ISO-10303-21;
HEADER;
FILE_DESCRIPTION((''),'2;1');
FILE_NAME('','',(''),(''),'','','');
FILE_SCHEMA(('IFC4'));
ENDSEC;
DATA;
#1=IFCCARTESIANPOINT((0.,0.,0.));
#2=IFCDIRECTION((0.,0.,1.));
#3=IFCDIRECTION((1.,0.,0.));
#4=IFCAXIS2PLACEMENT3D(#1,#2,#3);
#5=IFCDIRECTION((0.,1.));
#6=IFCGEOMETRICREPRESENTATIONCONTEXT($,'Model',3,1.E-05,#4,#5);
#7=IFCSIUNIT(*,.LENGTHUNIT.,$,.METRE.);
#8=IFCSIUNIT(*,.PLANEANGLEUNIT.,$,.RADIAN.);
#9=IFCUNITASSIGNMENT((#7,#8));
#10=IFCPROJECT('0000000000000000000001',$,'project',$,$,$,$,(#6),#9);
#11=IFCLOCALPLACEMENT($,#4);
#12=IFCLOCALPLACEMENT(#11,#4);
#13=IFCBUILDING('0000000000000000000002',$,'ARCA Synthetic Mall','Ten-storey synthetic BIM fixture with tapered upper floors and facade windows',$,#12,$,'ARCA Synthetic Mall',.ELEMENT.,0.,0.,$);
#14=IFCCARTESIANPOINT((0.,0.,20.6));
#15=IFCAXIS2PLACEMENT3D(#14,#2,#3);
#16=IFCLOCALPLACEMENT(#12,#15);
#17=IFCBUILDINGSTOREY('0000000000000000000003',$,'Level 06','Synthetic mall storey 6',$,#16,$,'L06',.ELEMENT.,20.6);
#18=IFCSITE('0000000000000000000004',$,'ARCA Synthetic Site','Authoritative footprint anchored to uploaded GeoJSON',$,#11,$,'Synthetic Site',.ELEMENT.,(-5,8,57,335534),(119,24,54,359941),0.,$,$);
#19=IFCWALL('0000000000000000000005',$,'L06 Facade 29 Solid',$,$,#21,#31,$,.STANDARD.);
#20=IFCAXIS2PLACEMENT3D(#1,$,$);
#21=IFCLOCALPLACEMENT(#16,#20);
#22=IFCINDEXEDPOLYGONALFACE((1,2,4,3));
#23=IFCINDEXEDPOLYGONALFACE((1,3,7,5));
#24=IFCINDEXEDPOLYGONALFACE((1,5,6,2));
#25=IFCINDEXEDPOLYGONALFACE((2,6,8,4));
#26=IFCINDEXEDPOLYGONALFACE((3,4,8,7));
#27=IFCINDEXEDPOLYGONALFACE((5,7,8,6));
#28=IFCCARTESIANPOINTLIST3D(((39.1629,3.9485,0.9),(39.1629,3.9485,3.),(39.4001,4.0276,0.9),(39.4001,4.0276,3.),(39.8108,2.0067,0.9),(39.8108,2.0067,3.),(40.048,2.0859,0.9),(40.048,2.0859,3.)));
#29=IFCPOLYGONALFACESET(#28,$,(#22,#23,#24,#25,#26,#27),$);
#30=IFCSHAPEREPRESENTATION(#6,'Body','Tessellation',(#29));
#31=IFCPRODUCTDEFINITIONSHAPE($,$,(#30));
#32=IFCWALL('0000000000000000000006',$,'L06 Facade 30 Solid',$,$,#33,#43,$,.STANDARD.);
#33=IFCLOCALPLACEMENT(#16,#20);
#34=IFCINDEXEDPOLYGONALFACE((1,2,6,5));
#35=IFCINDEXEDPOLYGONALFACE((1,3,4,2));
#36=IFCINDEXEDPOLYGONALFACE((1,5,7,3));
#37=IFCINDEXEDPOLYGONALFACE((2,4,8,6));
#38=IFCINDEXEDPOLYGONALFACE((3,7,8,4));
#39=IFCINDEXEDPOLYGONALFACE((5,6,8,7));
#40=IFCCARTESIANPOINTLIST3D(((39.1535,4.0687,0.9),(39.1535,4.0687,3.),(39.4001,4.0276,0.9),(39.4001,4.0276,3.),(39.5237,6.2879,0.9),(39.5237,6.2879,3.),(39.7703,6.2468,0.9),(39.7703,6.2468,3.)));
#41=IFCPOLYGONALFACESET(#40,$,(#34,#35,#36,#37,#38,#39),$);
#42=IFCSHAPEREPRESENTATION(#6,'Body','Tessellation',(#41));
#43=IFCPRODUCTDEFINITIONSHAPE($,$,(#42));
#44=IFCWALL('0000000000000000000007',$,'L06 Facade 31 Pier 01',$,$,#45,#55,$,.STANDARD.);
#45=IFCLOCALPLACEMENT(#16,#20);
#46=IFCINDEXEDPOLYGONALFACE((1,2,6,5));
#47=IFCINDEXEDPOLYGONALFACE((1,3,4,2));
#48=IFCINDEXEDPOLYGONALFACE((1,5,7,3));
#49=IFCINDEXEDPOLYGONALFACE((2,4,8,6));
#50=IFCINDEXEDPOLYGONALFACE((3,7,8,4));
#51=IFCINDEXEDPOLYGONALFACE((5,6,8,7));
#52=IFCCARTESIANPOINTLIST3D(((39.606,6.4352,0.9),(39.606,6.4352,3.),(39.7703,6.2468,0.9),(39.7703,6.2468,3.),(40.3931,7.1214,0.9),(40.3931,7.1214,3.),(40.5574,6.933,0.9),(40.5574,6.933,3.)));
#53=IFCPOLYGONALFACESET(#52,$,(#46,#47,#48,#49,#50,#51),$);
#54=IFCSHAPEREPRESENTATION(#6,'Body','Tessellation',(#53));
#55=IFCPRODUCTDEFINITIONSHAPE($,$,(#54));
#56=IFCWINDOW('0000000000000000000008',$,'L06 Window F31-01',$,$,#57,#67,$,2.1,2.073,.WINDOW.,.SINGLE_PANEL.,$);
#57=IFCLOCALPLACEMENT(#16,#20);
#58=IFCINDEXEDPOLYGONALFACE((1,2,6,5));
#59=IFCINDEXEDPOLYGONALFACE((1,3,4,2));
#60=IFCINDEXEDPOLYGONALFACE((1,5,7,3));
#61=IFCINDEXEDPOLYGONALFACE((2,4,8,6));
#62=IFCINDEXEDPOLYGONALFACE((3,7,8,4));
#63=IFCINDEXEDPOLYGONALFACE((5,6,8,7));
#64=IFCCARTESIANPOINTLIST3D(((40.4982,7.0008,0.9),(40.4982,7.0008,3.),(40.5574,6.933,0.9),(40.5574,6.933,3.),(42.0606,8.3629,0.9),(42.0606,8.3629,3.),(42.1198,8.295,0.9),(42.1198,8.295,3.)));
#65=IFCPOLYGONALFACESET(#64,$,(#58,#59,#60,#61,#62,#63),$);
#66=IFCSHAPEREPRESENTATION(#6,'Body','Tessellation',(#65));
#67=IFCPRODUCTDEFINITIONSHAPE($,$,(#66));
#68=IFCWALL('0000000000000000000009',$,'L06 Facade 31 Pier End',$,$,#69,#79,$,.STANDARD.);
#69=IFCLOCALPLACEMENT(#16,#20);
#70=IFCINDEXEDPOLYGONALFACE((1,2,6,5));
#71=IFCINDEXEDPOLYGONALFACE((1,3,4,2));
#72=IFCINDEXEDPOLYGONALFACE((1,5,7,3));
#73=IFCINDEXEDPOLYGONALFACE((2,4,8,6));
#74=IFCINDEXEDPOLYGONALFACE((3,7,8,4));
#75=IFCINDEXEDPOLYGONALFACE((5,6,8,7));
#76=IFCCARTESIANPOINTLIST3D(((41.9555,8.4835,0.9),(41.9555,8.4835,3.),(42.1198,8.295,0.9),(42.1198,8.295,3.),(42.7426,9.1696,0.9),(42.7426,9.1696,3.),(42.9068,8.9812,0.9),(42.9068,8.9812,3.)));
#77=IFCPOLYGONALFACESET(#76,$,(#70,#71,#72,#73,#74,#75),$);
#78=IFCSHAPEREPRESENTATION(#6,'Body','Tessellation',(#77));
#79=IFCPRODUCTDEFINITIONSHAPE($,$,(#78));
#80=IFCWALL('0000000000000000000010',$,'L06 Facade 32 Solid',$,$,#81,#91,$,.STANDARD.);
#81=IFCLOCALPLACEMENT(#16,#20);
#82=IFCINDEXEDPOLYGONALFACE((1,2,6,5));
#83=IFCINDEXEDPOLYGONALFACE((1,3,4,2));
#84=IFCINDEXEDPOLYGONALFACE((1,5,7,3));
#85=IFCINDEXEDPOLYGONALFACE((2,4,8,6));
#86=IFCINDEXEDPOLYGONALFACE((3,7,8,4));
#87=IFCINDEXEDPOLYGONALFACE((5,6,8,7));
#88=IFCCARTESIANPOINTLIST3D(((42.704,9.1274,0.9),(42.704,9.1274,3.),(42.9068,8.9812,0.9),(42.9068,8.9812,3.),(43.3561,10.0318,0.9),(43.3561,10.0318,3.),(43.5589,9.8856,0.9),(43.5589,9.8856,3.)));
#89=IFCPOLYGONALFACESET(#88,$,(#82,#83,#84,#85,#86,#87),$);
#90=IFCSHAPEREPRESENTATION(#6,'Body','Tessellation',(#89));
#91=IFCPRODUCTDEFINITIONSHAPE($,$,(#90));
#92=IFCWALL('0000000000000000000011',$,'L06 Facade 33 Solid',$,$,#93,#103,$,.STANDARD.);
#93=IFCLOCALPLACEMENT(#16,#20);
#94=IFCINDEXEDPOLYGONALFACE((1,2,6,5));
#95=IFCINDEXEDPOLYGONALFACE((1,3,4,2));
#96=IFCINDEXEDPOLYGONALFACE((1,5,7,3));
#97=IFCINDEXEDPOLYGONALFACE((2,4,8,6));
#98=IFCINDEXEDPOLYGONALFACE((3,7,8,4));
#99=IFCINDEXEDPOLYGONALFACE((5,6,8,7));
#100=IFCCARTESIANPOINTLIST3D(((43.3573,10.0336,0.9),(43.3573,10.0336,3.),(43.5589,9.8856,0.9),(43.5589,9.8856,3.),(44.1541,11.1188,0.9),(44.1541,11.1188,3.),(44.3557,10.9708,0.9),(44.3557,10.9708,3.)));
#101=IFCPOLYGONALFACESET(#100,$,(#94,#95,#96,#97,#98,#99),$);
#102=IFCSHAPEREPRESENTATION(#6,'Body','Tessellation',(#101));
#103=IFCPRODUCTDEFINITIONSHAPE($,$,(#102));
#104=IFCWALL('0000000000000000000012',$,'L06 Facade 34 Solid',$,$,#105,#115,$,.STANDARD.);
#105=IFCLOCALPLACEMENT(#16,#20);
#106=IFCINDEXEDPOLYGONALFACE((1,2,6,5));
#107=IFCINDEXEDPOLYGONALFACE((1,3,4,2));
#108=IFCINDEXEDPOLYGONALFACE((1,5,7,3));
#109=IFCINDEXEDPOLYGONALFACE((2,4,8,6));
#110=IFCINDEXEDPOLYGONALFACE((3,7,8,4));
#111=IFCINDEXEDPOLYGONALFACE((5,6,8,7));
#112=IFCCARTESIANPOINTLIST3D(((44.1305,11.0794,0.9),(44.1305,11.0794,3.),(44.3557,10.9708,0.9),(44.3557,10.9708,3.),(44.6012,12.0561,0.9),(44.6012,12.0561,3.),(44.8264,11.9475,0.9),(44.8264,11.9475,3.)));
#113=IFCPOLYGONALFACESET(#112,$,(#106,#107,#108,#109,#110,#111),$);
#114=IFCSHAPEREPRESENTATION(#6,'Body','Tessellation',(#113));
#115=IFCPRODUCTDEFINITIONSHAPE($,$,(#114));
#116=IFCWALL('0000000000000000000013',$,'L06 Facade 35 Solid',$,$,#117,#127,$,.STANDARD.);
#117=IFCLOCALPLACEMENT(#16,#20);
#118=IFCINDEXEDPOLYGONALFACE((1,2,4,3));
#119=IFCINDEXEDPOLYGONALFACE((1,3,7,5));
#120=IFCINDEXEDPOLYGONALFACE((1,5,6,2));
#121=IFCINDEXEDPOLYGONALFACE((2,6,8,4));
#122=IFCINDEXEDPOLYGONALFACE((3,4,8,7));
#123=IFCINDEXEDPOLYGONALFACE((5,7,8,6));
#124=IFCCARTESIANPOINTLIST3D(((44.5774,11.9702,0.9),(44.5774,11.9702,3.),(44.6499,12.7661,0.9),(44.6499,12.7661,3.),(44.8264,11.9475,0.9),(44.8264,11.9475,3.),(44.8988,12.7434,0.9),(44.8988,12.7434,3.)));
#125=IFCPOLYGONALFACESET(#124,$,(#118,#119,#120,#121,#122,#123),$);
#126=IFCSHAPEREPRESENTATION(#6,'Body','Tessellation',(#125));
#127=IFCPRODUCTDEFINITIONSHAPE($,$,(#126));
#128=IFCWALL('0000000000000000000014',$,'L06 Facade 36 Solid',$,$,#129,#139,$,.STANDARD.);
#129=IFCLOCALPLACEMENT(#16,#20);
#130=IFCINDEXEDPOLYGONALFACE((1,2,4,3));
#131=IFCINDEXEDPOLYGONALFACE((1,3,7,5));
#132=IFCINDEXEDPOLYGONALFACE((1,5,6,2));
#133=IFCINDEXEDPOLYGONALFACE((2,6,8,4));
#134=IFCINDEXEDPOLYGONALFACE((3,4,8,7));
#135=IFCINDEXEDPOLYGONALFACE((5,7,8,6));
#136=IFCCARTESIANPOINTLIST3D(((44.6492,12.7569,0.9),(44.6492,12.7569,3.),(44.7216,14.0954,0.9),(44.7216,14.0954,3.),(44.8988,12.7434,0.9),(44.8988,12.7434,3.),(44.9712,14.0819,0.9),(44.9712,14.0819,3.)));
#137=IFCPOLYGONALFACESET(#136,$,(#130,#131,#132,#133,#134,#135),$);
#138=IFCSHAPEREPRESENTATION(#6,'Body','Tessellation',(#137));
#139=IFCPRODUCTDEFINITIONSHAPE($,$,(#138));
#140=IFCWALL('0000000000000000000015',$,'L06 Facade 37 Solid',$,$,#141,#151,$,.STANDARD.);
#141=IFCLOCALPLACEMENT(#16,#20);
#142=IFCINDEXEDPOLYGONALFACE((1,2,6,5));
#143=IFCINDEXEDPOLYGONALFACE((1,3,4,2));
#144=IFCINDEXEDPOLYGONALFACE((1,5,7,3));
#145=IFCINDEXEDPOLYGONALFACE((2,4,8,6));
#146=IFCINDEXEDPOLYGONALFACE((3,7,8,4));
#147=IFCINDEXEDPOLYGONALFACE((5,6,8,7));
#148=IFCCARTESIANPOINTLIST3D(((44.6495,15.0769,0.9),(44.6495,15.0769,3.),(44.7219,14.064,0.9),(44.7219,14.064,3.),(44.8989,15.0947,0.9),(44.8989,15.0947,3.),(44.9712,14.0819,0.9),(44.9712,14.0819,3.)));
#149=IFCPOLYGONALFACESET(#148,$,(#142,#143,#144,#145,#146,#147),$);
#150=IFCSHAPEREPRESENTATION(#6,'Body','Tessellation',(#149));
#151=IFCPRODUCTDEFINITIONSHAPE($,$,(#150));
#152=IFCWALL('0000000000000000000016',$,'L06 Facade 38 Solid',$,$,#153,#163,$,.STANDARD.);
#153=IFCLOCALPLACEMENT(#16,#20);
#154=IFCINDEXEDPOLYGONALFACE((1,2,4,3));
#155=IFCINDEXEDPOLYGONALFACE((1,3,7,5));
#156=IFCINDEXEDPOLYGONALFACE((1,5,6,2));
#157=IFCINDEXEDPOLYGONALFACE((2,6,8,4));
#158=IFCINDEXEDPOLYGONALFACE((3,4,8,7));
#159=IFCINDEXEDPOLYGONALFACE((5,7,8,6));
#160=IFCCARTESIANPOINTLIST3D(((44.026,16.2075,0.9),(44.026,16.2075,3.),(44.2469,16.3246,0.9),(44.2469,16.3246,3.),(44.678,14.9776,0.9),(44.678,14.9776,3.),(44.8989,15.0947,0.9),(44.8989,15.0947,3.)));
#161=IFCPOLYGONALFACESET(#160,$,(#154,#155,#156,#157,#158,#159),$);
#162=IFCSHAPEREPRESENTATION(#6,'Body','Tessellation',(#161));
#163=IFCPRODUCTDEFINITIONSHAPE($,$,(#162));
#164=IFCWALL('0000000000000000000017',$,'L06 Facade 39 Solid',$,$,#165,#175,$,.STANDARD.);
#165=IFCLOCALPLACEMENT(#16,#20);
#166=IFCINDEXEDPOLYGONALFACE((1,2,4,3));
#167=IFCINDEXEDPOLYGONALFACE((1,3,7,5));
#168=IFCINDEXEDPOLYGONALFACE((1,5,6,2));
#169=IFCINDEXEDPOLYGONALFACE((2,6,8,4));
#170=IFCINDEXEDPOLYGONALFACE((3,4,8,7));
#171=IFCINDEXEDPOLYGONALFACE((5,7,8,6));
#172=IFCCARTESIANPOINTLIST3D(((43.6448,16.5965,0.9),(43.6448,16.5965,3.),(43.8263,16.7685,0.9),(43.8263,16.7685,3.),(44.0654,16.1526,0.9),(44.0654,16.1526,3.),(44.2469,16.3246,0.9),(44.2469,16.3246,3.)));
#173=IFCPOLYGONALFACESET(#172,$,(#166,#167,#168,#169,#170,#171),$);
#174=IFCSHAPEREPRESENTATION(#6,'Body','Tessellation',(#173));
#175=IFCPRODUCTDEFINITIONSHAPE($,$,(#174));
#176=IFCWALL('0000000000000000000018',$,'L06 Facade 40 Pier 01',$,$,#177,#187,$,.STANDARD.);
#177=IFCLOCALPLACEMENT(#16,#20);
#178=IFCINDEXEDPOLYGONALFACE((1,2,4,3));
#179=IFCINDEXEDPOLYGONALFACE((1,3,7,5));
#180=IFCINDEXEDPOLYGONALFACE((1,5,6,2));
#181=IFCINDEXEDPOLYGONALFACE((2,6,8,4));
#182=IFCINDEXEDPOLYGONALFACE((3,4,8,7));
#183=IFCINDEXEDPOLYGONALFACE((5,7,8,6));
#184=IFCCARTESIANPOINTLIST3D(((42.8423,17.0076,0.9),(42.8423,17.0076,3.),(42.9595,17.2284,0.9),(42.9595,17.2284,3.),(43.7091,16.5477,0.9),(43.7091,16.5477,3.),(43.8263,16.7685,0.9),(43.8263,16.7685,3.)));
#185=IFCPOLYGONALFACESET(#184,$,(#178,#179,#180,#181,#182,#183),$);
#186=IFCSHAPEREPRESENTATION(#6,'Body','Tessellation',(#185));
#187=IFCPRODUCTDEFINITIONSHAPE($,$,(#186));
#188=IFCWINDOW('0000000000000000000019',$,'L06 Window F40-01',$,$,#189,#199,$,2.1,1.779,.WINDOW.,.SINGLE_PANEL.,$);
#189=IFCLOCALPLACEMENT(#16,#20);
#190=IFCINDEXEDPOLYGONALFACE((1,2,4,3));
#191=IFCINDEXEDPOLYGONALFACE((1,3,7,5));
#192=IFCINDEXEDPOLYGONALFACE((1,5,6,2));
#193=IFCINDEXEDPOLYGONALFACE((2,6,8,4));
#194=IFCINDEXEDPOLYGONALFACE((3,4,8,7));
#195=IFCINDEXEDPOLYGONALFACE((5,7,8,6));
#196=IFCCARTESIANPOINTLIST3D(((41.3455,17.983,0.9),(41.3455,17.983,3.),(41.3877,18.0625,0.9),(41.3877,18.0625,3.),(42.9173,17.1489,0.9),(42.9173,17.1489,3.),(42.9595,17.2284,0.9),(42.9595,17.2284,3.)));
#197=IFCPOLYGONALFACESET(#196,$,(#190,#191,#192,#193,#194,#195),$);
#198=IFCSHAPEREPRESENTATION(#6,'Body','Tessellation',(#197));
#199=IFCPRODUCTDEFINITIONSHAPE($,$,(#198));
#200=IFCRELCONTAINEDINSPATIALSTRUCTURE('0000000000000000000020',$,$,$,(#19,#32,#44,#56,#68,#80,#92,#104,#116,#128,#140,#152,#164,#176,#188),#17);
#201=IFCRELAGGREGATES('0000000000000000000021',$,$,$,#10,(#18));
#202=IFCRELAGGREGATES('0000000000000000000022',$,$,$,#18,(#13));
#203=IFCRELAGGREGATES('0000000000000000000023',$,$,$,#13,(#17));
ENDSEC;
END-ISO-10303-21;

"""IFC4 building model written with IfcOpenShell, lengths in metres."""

from ifc_helpers import new_model, si_unit, direction, frame, origin_with_axes, place, context, project, spatial, polyline, outline, extrude, element, save


model = new_model("IFC4")

# Units and contexts
model_context = context("Model", 3, precision=1e-05, world=origin_with_axes(), true_north=direction((0.0, 1.0)))
ifc_project = project(units=[si_unit("LENGTHUNIT", "METRE"), si_unit("PLANEANGLEUNIT", "RADIAN")], contexts=[model_context])

# Site, building, storey
site_placement = place(None, origin_with_axes())
site = spatial("IfcSite", under=ifc_project, at=site_placement, Name="ARCA Synthetic Site", Description="Authoritative footprint anchored to uploaded GeoJSON", LongName="Synthetic Site", CompositionType="ELEMENT", RefLatitude=(-5, 8, 57, 335534), RefLongitude=(119, 24, 54, 359941), RefElevation=0.0)
building_placement = place(site_placement, origin_with_axes())
building = spatial("IfcBuilding", under=site, at=building_placement, Name="ARCA Synthetic Mall", Description="Ten-storey synthetic BIM fixture with tapered upper floors and facade windows", LongName="ARCA Synthetic Mall", CompositionType="ELEMENT", ElevationOfRefHeight=0.0, ElevationOfTerrain=0.0)
storey_placement = place(building_placement, frame((0.0, 0.0, 20.6), z_axis=(0.0, 0.0, 1.0), x_axis=(1.0, 0.0, 0.0)))
storey = spatial("IfcBuildingStorey", under=building, at=storey_placement, Name="Level 06", Description="Synthetic mall storey 6", LongName="L06", CompositionType="ELEMENT", Elevation=20.6)

# Walls
wall_1_placement = place(storey_placement, frame((0.0, 0.0, 0.9), z_axis=(0.0, 0.0, 1.0), x_axis=(1.0, 0.0, 0.0)))
element("IfcWall", 1, at=wall_1_placement, inside=storey, Name="L06 Facade 29 Solid", PredefinedType="STANDARD", context=model_context, shape_type="SweptSolid", body=[
    extrude(outline(polyline([(40.048, 2.0859), (39.4001, 4.0276), (39.1629, 3.9485), (39.8108, 2.0067), (40.048, 2.0859)])), origin_with_axes(), (0.0, 0.0, 1.0), 2.1),
])
wall_2_placement = place(storey_placement, frame((0.0, 0.0, 0.9), z_axis=(0.0, 0.0, 1.0), x_axis=(1.0, 0.0, 0.0)))
element("IfcWall", 2, at=wall_2_placement, inside=storey, Name="L06 Facade 30 Solid", PredefinedType="STANDARD", context=model_context, shape_type="SweptSolid", body=[
    extrude(outline(polyline([(39.4001, 4.0276), (39.7703, 6.2468), (39.5237, 6.2879), (39.1535, 4.0687), (39.4001, 4.0276)])), origin_with_axes(), (0.0, 0.0, 1.0), 2.1),
])
wall_3_placement = place(storey_placement, frame((0.0, 0.0, 0.9), z_axis=(0.0, 0.0, 1.0), x_axis=(1.0, 0.0, 0.0)))
element("IfcWall", 3, at=wall_3_placement, inside=storey, Name="L06 Facade 31 Pier 01", PredefinedType="STANDARD", context=model_context, shape_type="SweptSolid", body=[
    extrude(outline(polyline([(39.7703, 6.2468), (40.5574, 6.933), (40.3931, 7.1214), (39.606, 6.4352), (39.7703, 6.2468)])), origin_with_axes(), (0.0, 0.0, 1.0), 2.1),
])

# Window
window_1_placement = place(storey_placement, frame((0.0, 0.0, 0.9), z_axis=(0.0, 0.0, 1.0), x_axis=(1.0, 0.0, 0.0)))
element("IfcWindow", 4, at=window_1_placement, inside=storey, Name="L06 Window F31-01", OverallHeight=2.1, OverallWidth=2.073, PartitioningType="SINGLE_PANEL", PredefinedType="WINDOW", context=model_context, shape_type="SweptSolid", body=[
    extrude(outline(polyline([(40.5574, 6.933), (42.1198, 8.295), (42.0606, 8.3629), (40.4982, 7.0008), (40.5574, 6.933)])), origin_with_axes(), (0.0, 0.0, 1.0), 2.1),
])

# Walls
wall_4_placement = place(storey_placement, frame((0.0, 0.0, 0.9), z_axis=(0.0, 0.0, 1.0), x_axis=(1.0, 0.0, 0.0)))
element("IfcWall", 5, at=wall_4_placement, inside=storey, Name="L06 Facade 31 Pier End", PredefinedType="STANDARD", context=model_context, shape_type="SweptSolid", body=[
    extrude(outline(polyline([(42.1198, 8.295), (42.9068, 8.9812), (42.7426, 9.1696), (41.9555, 8.4835), (42.1198, 8.295)])), origin_with_axes(), (0.0, 0.0, 1.0), 2.1),
])
wall_5_placement = place(storey_placement, frame((0.0, 0.0, 0.9), z_axis=(0.0, 0.0, 1.0), x_axis=(1.0, 0.0, 0.0)))
element("IfcWall", 6, at=wall_5_placement, inside=storey, Name="L06 Facade 32 Solid", PredefinedType="STANDARD", context=model_context, shape_type="SweptSolid", body=[
    extrude(outline(polyline([(42.9068, 8.9812), (43.5589, 9.8856), (43.3561, 10.0318), (42.704, 9.1274), (42.9068, 8.9812)])), origin_with_axes(), (0.0, 0.0, 1.0), 2.1),
])
wall_6_placement = place(storey_placement, frame((0.0, 0.0, 0.9), z_axis=(0.0, 0.0, 1.0), x_axis=(1.0, 0.0, 0.0)))
element("IfcWall", 7, at=wall_6_placement, inside=storey, Name="L06 Facade 33 Solid", PredefinedType="STANDARD", context=model_context, shape_type="SweptSolid", body=[
    extrude(outline(polyline([(43.5589, 9.8856), (44.3557, 10.9708), (44.1541, 11.1188), (43.3573, 10.0336), (43.5589, 9.8856)])), origin_with_axes(), (0.0, 0.0, 1.0), 2.1),
])
wall_7_placement = place(storey_placement, frame((0.0, 0.0, 0.9), z_axis=(0.0, 0.0, 1.0), x_axis=(1.0, 0.0, 0.0)))
element("IfcWall", 8, at=wall_7_placement, inside=storey, Name="L06 Facade 34 Solid", PredefinedType="STANDARD", context=model_context, shape_type="SweptSolid", body=[
    extrude(outline(polyline([(44.3557, 10.9708), (44.8264, 11.9475), (44.6012, 12.0561), (44.1305, 11.0794), (44.3557, 10.9708)])), origin_with_axes(), (0.0, 0.0, 1.0), 2.1),
])
wall_8_placement = place(storey_placement, frame((0.0, 0.0, 0.9), z_axis=(0.0, 0.0, 1.0), x_axis=(1.0, 0.0, 0.0)))
element("IfcWall", 9, at=wall_8_placement, inside=storey, Name="L06 Facade 35 Solid", PredefinedType="STANDARD", context=model_context, shape_type="SweptSolid", body=[
    extrude(outline(polyline([(44.8264, 11.9475), (44.8988, 12.7434), (44.6499, 12.7661), (44.5774, 11.9702), (44.8264, 11.9475)])), origin_with_axes(), (0.0, 0.0, 1.0), 2.1),
])
wall_9_placement = place(storey_placement, frame((0.0, 0.0, 0.9), z_axis=(0.0, 0.0, 1.0), x_axis=(1.0, 0.0, 0.0)))
element("IfcWall", 10, at=wall_9_placement, inside=storey, Name="L06 Facade 36 Solid", PredefinedType="STANDARD", context=model_context, shape_type="SweptSolid", body=[
    extrude(outline(polyline([(44.8988, 12.7434), (44.9712, 14.0819), (44.7216, 14.0954), (44.6492, 12.7569), (44.8988, 12.7434)])), origin_with_axes(), (0.0, 0.0, 1.0), 2.1),
])
wall_10_placement = place(storey_placement, frame((0.0, 0.0, 0.9), z_axis=(0.0, 0.0, 1.0), x_axis=(1.0, 0.0, 0.0)))
element("IfcWall", 11, at=wall_10_placement, inside=storey, Name="L06 Facade 37 Solid", PredefinedType="STANDARD", context=model_context, shape_type="SweptSolid", body=[
    extrude(outline(polyline([(44.9712, 14.0819), (44.8989, 15.0947), (44.6495, 15.0769), (44.7219, 14.064), (44.9712, 14.0819)])), origin_with_axes(), (0.0, 0.0, 1.0), 2.1),
])
wall_11_placement = place(storey_placement, frame((0.0, 0.0, 0.9), z_axis=(0.0, 0.0, 1.0), x_axis=(1.0, 0.0, 0.0)))
element("IfcWall", 12, at=wall_11_placement, inside=storey, Name="L06 Facade 38 Solid", PredefinedType="STANDARD", context=model_context, shape_type="SweptSolid", body=[
    extrude(outline(polyline([(44.8989, 15.0947), (44.2469, 16.3246), (44.026, 16.2075), (44.678, 14.9776), (44.8989, 15.0947)])), origin_with_axes(), (0.0, 0.0, 1.0), 2.1),
])
wall_12_placement = place(storey_placement, frame((0.0, 0.0, 0.9), z_axis=(0.0, 0.0, 1.0), x_axis=(1.0, 0.0, 0.0)))
element("IfcWall", 13, at=wall_12_placement, inside=storey, Name="L06 Facade 39 Solid", PredefinedType="STANDARD", context=model_context, shape_type="SweptSolid", body=[
    extrude(outline(polyline([(44.2469, 16.3246), (43.8263, 16.7685), (43.6448, 16.5965), (44.0654, 16.1526), (44.2469, 16.3246)])), origin_with_axes(), (0.0, 0.0, 1.0), 2.1),
])
wall_13_placement = place(storey_placement, frame((0.0, 0.0, 0.9), z_axis=(0.0, 0.0, 1.0), x_axis=(1.0, 0.0, 0.0)))
element("IfcWall", 14, at=wall_13_placement, inside=storey, Name="L06 Facade 40 Pier 01", PredefinedType="STANDARD", context=model_context, shape_type="SweptSolid", body=[
    extrude(outline(polyline([(43.8263, 16.7685), (42.9595, 17.2284), (42.8423, 17.0076), (43.7091, 16.5477), (43.8263, 16.7685)])), origin_with_axes(), (0.0, 0.0, 1.0), 2.1),
])

# Window
window_2_placement = place(storey_placement, frame((0.0, 0.0, 0.9), z_axis=(0.0, 0.0, 1.0), x_axis=(1.0, 0.0, 0.0)))
element("IfcWindow", 15, at=window_2_placement, inside=storey, Name="L06 Window F40-01", OverallHeight=2.1, OverallWidth=1.779, PartitioningType="SINGLE_PANEL", PredefinedType="WINDOW", context=model_context, shape_type="SweptSolid", body=[
    extrude(outline(polyline([(42.9595, 17.2284), (41.3877, 18.0625), (41.3455, 17.983), (42.9173, 17.1489), (42.9595, 17.2284)])), origin_with_axes(), (0.0, 0.0, 1.0), 2.1),
])

save(model, "model.ifc")
